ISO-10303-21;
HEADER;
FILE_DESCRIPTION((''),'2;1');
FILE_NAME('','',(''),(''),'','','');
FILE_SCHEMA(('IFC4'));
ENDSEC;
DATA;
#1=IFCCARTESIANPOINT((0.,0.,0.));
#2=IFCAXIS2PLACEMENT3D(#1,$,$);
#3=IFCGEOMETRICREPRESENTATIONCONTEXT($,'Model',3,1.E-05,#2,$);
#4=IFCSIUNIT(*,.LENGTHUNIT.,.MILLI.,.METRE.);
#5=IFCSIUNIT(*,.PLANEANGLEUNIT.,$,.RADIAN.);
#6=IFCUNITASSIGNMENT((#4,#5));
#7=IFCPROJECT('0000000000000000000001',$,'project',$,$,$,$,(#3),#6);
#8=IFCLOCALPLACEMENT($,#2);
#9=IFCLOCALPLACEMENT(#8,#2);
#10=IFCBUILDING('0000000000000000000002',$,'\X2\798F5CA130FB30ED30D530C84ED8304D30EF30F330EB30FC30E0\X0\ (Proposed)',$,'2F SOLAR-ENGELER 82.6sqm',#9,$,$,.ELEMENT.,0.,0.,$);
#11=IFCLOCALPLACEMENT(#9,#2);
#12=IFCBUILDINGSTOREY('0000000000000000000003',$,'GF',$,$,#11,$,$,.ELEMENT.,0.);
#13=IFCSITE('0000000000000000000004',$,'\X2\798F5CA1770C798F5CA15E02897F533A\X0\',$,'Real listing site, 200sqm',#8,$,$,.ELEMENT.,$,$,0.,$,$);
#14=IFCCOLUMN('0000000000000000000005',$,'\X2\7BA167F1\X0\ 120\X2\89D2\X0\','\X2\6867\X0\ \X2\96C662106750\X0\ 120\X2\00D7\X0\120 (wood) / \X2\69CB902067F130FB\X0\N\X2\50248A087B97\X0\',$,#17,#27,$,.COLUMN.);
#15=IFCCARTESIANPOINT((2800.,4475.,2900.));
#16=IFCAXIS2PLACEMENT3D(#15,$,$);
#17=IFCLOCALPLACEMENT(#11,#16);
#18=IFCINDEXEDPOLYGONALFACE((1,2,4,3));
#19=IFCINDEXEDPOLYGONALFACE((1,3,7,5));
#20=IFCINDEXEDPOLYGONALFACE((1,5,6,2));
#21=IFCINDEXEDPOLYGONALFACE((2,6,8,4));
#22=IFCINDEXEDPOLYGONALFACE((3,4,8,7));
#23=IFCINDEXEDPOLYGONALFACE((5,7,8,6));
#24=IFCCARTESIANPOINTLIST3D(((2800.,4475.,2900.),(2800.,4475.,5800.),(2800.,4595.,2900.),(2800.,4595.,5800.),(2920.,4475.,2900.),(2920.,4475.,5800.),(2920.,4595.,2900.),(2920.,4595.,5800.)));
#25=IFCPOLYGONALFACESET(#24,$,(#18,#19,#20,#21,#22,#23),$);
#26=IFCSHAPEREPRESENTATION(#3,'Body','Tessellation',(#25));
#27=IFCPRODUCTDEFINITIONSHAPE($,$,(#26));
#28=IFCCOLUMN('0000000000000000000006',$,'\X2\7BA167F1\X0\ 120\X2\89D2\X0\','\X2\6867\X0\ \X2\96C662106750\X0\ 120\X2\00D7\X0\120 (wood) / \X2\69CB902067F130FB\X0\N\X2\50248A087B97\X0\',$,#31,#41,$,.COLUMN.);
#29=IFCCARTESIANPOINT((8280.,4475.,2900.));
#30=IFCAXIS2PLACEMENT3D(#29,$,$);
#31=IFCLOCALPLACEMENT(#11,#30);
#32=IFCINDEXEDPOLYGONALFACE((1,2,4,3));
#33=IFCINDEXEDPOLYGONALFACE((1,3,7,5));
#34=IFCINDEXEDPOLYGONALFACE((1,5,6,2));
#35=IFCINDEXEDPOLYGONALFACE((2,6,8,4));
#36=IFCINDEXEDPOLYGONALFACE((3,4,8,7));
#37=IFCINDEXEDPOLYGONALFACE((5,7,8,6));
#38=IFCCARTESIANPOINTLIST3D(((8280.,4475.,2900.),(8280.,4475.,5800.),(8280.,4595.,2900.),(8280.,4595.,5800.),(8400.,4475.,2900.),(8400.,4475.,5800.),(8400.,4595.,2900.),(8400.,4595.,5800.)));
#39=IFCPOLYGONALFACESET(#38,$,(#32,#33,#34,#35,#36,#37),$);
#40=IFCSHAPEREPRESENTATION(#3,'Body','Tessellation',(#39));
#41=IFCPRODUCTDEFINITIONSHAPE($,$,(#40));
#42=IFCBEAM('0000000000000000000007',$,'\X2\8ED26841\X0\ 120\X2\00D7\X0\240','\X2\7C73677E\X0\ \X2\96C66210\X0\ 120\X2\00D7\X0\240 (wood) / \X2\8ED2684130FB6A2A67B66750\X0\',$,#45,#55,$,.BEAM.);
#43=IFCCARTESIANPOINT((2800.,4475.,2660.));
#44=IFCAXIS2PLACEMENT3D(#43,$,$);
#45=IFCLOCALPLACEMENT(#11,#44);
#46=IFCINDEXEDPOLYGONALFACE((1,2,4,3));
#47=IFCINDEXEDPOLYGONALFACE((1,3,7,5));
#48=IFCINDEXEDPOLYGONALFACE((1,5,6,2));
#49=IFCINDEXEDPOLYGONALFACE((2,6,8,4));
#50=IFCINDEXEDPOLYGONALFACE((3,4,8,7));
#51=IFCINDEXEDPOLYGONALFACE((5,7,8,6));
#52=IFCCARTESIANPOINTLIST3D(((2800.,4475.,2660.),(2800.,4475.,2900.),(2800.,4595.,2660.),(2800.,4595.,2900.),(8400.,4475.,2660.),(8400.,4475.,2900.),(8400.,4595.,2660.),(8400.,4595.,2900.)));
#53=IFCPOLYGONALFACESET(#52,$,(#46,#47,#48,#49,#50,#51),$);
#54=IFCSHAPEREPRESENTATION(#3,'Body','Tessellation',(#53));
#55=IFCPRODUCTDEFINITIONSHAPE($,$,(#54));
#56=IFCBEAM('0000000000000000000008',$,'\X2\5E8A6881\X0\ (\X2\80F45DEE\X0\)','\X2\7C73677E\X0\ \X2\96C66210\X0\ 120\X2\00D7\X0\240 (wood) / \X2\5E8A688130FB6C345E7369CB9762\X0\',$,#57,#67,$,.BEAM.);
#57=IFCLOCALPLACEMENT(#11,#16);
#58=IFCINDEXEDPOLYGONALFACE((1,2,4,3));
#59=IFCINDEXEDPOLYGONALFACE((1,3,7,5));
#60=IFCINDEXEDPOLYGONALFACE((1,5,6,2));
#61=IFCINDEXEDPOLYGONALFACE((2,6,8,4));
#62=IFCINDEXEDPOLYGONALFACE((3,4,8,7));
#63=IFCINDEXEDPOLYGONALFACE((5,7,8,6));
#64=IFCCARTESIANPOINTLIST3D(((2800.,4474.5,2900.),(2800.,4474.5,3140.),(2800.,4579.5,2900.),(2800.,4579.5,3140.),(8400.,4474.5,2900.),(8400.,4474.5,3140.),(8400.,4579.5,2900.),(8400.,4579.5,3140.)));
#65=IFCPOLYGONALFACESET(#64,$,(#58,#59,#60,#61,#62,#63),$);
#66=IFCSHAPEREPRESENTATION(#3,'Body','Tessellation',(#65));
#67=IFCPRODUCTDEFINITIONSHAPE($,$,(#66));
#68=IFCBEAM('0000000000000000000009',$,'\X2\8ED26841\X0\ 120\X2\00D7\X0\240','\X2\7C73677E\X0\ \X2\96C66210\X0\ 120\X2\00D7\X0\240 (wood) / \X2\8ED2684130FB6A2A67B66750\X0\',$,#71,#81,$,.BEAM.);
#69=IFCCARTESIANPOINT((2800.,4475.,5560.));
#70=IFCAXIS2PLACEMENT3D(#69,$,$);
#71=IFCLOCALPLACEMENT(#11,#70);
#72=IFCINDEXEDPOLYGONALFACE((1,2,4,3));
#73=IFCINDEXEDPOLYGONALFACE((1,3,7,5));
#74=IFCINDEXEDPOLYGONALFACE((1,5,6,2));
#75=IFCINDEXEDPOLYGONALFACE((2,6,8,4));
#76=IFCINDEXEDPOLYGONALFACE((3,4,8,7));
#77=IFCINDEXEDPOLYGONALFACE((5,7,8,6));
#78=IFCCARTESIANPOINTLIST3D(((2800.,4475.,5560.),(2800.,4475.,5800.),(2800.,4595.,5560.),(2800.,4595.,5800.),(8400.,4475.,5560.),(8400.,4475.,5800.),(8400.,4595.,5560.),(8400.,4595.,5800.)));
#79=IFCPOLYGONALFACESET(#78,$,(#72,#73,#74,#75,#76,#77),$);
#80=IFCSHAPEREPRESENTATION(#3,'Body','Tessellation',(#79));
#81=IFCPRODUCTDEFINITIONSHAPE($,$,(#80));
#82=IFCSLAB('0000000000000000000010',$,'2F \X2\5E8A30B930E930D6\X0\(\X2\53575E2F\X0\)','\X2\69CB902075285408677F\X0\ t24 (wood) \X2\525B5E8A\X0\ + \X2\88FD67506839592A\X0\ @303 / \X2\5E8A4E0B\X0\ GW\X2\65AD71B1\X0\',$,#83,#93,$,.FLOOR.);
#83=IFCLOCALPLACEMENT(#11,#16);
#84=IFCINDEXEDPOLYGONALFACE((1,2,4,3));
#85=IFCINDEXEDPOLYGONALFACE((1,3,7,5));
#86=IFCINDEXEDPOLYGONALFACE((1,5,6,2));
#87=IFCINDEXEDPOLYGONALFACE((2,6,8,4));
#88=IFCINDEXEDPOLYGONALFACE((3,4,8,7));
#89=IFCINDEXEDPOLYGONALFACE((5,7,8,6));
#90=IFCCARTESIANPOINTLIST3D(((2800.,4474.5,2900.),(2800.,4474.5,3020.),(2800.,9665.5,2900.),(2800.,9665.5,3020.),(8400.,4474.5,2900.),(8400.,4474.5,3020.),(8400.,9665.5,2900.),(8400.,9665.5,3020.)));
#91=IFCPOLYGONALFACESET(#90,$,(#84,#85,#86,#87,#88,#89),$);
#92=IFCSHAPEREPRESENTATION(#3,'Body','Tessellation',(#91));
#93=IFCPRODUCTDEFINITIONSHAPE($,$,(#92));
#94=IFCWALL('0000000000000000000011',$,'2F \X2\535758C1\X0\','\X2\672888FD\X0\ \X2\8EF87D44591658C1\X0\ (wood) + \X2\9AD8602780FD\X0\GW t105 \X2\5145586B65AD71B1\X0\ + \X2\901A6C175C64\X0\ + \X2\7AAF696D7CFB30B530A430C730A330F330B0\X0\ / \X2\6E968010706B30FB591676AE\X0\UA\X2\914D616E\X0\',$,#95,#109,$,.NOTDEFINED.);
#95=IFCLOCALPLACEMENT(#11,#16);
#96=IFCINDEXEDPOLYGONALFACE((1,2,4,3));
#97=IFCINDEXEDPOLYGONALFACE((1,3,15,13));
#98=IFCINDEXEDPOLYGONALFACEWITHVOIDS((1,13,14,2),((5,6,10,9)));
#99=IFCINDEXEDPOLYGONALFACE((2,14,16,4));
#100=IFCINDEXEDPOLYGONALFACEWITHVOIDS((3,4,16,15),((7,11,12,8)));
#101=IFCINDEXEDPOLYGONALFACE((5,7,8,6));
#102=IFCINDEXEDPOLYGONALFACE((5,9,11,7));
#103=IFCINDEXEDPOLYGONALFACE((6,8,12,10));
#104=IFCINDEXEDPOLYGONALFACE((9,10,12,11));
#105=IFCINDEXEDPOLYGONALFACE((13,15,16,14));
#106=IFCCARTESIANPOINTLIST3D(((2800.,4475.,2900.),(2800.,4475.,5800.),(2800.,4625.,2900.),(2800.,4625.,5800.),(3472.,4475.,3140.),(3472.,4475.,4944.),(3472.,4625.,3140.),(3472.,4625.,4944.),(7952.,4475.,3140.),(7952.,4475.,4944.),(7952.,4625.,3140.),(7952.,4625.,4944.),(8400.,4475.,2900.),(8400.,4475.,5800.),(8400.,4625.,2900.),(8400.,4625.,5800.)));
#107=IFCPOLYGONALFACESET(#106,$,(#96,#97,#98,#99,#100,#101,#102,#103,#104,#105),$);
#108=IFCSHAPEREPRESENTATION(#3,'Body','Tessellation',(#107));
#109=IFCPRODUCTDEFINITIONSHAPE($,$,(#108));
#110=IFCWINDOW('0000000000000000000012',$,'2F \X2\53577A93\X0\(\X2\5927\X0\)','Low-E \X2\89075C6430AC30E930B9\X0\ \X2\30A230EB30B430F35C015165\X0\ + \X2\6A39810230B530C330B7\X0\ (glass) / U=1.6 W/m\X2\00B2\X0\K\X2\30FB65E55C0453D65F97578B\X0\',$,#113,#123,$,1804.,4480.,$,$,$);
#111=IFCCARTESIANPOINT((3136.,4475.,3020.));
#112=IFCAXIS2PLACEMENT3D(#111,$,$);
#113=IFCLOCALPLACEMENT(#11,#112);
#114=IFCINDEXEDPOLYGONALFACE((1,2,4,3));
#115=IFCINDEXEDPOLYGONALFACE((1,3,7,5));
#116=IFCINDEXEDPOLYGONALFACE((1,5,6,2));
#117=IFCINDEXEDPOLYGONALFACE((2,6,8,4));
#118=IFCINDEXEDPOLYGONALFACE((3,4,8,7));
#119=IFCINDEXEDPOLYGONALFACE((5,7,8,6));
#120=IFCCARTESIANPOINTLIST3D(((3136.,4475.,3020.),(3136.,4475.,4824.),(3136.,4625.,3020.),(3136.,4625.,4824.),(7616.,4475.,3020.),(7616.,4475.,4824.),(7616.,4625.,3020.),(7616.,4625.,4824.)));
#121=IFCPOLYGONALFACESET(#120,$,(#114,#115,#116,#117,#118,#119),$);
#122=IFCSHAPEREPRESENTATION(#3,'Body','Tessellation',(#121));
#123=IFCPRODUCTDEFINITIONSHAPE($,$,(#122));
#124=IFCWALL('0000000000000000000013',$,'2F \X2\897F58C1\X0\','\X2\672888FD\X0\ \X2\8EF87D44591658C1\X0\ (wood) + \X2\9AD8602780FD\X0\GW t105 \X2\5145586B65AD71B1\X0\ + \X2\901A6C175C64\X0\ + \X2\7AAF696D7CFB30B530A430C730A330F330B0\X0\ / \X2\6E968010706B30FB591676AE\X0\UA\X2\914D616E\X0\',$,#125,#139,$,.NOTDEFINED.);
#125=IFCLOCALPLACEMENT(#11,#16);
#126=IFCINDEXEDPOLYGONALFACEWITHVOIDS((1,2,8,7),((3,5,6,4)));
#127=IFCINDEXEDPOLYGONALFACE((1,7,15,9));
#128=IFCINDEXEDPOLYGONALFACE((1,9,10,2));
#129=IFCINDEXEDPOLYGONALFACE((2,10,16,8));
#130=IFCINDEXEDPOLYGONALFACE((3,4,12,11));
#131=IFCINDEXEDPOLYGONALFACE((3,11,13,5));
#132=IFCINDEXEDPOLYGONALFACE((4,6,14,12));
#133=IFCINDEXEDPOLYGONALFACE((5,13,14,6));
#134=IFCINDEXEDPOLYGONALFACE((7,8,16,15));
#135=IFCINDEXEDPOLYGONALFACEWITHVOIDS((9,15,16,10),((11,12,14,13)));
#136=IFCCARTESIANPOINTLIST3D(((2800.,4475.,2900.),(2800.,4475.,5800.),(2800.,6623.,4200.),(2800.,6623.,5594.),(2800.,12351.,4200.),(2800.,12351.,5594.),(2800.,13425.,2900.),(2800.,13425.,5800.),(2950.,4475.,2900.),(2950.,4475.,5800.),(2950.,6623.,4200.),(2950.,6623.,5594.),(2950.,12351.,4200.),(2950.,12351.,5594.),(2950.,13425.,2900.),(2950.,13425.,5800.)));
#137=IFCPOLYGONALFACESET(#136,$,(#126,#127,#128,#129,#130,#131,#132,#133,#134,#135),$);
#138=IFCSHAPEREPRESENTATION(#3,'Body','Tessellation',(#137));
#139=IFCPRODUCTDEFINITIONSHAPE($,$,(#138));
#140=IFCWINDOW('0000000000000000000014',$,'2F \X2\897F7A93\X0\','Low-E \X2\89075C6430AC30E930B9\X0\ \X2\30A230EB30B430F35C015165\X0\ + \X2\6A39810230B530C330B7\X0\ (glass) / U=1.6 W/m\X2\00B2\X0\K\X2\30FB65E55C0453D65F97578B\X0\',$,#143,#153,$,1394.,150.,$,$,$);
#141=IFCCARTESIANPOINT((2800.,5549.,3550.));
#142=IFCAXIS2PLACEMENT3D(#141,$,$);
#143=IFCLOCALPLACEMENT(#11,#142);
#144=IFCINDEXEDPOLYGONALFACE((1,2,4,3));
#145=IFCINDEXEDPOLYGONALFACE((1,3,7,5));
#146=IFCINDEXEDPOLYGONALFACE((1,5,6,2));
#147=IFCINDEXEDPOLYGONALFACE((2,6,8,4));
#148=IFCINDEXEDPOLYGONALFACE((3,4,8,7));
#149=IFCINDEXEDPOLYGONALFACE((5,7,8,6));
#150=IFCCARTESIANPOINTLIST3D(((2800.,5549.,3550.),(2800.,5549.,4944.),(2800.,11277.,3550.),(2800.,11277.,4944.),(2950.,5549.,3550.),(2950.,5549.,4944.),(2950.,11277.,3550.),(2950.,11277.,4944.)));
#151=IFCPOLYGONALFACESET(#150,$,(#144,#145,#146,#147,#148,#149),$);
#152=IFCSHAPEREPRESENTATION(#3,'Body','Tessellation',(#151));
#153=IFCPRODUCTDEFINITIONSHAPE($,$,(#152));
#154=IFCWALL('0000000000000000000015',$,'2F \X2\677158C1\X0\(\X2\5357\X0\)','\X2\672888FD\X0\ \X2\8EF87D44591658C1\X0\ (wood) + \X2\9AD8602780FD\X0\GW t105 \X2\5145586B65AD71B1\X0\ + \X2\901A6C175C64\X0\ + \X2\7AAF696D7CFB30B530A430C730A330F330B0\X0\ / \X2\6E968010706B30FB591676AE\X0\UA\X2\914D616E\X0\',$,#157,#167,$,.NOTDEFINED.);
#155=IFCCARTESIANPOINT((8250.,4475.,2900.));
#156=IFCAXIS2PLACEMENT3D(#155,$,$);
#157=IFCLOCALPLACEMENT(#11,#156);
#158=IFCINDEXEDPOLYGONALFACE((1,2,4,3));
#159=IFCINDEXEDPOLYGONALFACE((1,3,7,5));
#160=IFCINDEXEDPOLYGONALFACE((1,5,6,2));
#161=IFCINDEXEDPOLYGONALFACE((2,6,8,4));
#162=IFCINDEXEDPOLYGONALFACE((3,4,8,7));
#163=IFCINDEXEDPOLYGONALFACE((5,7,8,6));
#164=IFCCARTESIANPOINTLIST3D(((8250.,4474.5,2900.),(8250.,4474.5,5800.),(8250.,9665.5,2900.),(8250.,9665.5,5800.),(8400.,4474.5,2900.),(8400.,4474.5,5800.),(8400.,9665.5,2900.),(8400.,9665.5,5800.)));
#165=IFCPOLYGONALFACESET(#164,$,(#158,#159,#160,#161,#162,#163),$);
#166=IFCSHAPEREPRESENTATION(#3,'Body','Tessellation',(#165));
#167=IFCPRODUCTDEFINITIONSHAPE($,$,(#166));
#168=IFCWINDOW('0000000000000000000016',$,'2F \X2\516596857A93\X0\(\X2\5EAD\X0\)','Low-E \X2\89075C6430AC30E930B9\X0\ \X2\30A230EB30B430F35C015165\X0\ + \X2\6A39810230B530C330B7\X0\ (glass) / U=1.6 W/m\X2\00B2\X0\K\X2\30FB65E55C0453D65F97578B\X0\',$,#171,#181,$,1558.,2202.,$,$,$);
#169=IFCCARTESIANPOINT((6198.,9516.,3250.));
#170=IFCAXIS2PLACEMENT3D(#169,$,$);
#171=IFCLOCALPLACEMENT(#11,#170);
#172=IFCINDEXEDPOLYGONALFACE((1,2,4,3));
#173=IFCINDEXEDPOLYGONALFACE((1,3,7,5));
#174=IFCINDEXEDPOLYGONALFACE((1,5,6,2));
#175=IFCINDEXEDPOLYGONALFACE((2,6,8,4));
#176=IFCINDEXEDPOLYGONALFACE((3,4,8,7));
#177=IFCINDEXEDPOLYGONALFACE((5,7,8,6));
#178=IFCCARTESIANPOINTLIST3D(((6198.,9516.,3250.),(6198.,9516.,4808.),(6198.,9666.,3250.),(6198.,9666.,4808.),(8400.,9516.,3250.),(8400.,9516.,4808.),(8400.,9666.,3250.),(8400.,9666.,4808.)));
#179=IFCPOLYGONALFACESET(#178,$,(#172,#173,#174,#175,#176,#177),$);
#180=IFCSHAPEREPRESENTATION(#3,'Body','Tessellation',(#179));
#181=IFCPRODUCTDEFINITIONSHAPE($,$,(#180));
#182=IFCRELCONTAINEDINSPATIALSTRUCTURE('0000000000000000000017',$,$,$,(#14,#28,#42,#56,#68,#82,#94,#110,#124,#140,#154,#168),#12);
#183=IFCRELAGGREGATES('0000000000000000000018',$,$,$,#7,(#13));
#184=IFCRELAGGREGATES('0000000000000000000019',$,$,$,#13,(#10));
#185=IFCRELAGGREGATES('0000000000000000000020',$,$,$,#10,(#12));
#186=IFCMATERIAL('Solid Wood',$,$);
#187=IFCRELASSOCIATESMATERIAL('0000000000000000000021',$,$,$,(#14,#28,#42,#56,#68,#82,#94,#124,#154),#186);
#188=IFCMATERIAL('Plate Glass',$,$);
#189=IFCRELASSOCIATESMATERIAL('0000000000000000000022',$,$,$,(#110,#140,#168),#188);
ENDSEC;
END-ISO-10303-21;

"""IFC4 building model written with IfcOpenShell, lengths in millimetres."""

from ifc_helpers import new_model, si_unit, frame, frame_2d, origin, place, context, project, spatial, rectangle, extrude, material, element, fill, save


model = new_model("IFC4")

# Units and contexts
model_context = context("Model", 3, precision=1e-05, world=origin())
ifc_project = project(units=[si_unit("LENGTHUNIT", "METRE", prefix="MILLI"), si_unit("PLANEANGLEUNIT", "RADIAN")], contexts=[model_context])

# Site, building, storey
site_placement = place(None, origin())
site = spatial("IfcSite", under=ifc_project, at=site_placement, Name="福岡県福岡市西区", ObjectType="Real listing site, 200sqm", CompositionType="ELEMENT", RefElevation=0.0)
building_placement = place(site_placement, origin())
building = spatial("IfcBuilding", under=site, at=building_placement, Name="福岡・ロフト付きワンルーム (Proposed)", ObjectType="2F SOLAR-ENGELER 82.6sqm", CompositionType="ELEMENT", ElevationOfRefHeight=0.0, ElevationOfTerrain=0.0)
storey_placement = place(building_placement, origin())
storey = spatial("IfcBuildingStorey", under=building, at=storey_placement, Name="GF", CompositionType="ELEMENT", Elevation=0.0)

# Columns
ifc_material_1 = material(Name="Solid Wood")
column_1_placement = place(storey_placement, frame((2800.0, 4475.0, 2900.0)))
element("IfcColumn", 1, at=column_1_placement, inside=storey, material=ifc_material_1, Name="管柱 120角", Description="桧 集成材 120×120 (wood) / 構造柱・N値計算", PredefinedType="COLUMN", context=model_context, shape_type="SweptSolid", body=[
    extrude(rectangle(XDim=120.0, YDim=120.0, at=frame_2d((60.0, 60.0))), frame((2800.0, 4475.0, 2900.0)), (0.0, 0.0, 1.0), 2900.0),
])
column_2_placement = place(storey_placement, frame((8280.0, 4475.0, 2900.0)))
element("IfcColumn", 2, at=column_2_placement, inside=storey, material=ifc_material_1, Name="管柱 120角", Description="桧 集成材 120×120 (wood) / 構造柱・N値計算", PredefinedType="COLUMN", context=model_context, shape_type="SweptSolid", body=[
    extrude(rectangle(XDim=120.0, YDim=120.0, at=frame_2d((60.0, 60.0))), frame((8280.0, 4475.0, 2900.0)), (0.0, 0.0, 1.0), 2900.0),
])

# Beams
beam_1_placement = place(storey_placement, frame((2800.0, 4475.0, 2660.0)))
element("IfcBeam", 3, at=beam_1_placement, inside=storey, material=ifc_material_1, Name="軒桁 120×240", Description="米松 集成 120×240 (wood) / 軒桁・横架材", PredefinedType="BEAM", context=model_context, shape_type="SweptSolid", body=[
    extrude(rectangle(XDim=5600.0, YDim=120.0, at=frame_2d((2800.0, 60.0))), frame((2800.0, 4475.0, 2660.0)), (0.0, 0.0, 1.0), 240.0),
])
beam_2_placement = place(storey_placement, frame((2800.0, 4475.0, 2900.0)))
element("IfcBeam", 4, at=beam_2_placement, inside=storey, material=ifc_material_1, Name="床梁 (胴差)", Description="米松 集成 120×240 (wood) / 床梁・水平構面", PredefinedType="BEAM", context=model_context, shape_type="SweptSolid", body=[
    extrude(rectangle(XDim=5600.0, YDim=105.0, at=frame_2d((2800.0, 52.0))), frame((2800.0, 4475.0, 2900.0)), (0.0, 0.0, 1.0), 240.0),
])
beam_3_placement = place(storey_placement, frame((2800.0, 4475.0, 5560.0)))
element("IfcBeam", 5, at=beam_3_placement, inside=storey, material=ifc_material_1, Name="軒桁 120×240", Description="米松 集成 120×240 (wood) / 軒桁・横架材", PredefinedType="BEAM", context=model_context, shape_type="SweptSolid", body=[
    extrude(rectangle(XDim=5600.0, YDim=120.0, at=frame_2d((2800.0, 60.0))), frame((2800.0, 4475.0, 5560.0)), (0.0, 0.0, 1.0), 240.0),
])

# Slab
slab_placement = place(storey_placement, frame((2800.0, 4475.0, 2900.0)))
element("IfcSlab", 6, at=slab_placement, inside=storey, material=ifc_material_1, Name="2F 床スラブ(南帯)", Description="構造用合板 t24 (wood) 剛床 + 製材根太 @303 / 床下 GW断熱", PredefinedType="FLOOR", context=model_context, shape_type="SweptSolid", body=[
    extrude(rectangle(XDim=5600.0, YDim=5191.0, at=frame_2d((2800.0, 2595.0))), frame((2800.0, 4475.0, 2900.0)), (0.0, 0.0, 1.0), 120.0),
])

# Walls, openings, windows
wall_1_placement = place(storey_placement, frame((2800.0, 4475.0, 2900.0)))
wall_1 = element("IfcWall", 7, at=wall_1_placement, inside=storey, material=ifc_material_1, Name="2F 南壁", Description="木製 軸組外壁 (wood) + 高性能GW t105 充填断熱 + 通気層 + 窯業系サイディング / 準耐火・外皮UA配慮", PredefinedType="NOTDEFINED", context=model_context, shape_type="SweptSolid", body=[
    extrude(rectangle(XDim=5600.0, YDim=150.0, at=frame_2d((2800.0, 75.0))), frame((2800.0, 4475.0, 2900.0)), (0.0, 0.0, 1.0), 2900.0),
])
opening_1_placement = place(storey_placement, frame((3136.0, 4475.0, 3020.0)))
opening_1 = element("IfcOpeningElement", 8, at=opening_1_placement, cuts=wall_1, PredefinedType="NOTDEFINED", context=model_context, shape_type="SweptSolid", body=[
    extrude(rectangle(XDim=4480.0, YDim=150.0, at=frame_2d((2240.0, 75.0))), frame((3136.0, 4475.0, 3020.0)), (0.0, 0.0, 1.0), 1804.0),
])
ifc_material_2 = material(Name="Plate Glass")
window_1_placement = place(storey_placement, frame((3136.0, 4475.0, 3020.0)))
window_1 = element("IfcWindow", 9, at=window_1_placement, inside=storey, material=ifc_material_2, Name="2F 南窓(大)", Description="Low-E 複層ガラス アルゴン封入 + 樹脂サッシ (glass) / U=1.6 W/m²K・日射取得型", OverallHeight=1804.0, OverallWidth=4480.0, context=model_context, shape_type="SweptSolid", body=[
    extrude(rectangle(XDim=4480.0, YDim=150.0, at=frame_2d((2240.0, 75.0))), frame((3136.0, 4475.0, 3020.0)), (0.0, 0.0, 1.0), 1804.0),
])
fill(opening_1, window_1)
wall_2_placement = place(storey_placement, frame((2800.0, 4475.0, 2900.0)))
wall_2 = element("IfcWall", 10, at=wall_2_placement, inside=storey, material=ifc_material_1, Name="2F 西壁", Description="木製 軸組外壁 (wood) + 高性能GW t105 充填断熱 + 通気層 + 窯業系サイディング / 準耐火・外皮UA配慮", PredefinedType="NOTDEFINED", context=model_context, shape_type="SweptSolid", body=[
    extrude(rectangle(XDim=150.0, YDim=8950.0, at=frame_2d((75.0, 4475.0))), frame((2800.0, 4475.0, 2900.0)), (0.0, 0.0, 1.0), 2900.0),
])
opening_2_placement = place(storey_placement, frame((2800.0, 5549.0, 3550.0)))
opening_2 = element("IfcOpeningElement", 11, at=opening_2_placement, cuts=wall_2, PredefinedType="NOTDEFINED", context=model_context, shape_type="SweptSolid", body=[
    extrude(rectangle(XDim=150.0, YDim=5728.0, at=frame_2d((75.0, 2864.0))), frame((2800.0, 5549.0, 3550.0)), (0.0, 0.0, 1.0), 1394.0),
])
window_2_placement = place(storey_placement, frame((2800.0, 5549.0, 3550.0)))
window_2 = element("IfcWindow", 12, at=window_2_placement, inside=storey, material=ifc_material_2, Name="2F 西窓", Description="Low-E 複層ガラス アルゴン封入 + 樹脂サッシ (glass) / U=1.6 W/m²K・日射取得型", OverallHeight=1394.0, OverallWidth=150.0, context=model_context, shape_type="SweptSolid", body=[
    extrude(rectangle(XDim=150.0, YDim=5728.0, at=frame_2d((75.0, 2864.0))), frame((2800.0, 5549.0, 3550.0)), (0.0, 0.0, 1.0), 1394.0),
])
fill(opening_2, window_2)
wall_3_placement = place(storey_placement, frame((8250.0, 4475.0, 2900.0)))
wall_3 = element("IfcWall", 13, at=wall_3_placement, inside=storey, material=ifc_material_1, Name="2F 東壁(南)", Description="木製 軸組外壁 (wood) + 高性能GW t105 充填断熱 + 通気層 + 窯業系サイディング / 準耐火・外皮UA配慮", PredefinedType="NOTDEFINED", context=model_context, shape_type="SweptSolid", body=[
    extrude(rectangle(XDim=150.0, YDim=5191.0, at=frame_2d((75.0, 2595.0))), frame((8250.0, 4475.0, 2900.0)), (0.0, 0.0, 1.0), 2900.0),
])
opening_3_placement = place(storey_placement, frame((6198.0, 9516.0, 3250.0)))
opening_3 = element("IfcOpeningElement", 14, at=opening_3_placement, cuts=wall_3, PredefinedType="NOTDEFINED", context=model_context, shape_type="SweptSolid", body=[
    extrude(rectangle(XDim=2202.0, YDim=150.0, at=frame_2d((1101.0, 75.0))), frame((6198.0, 9516.0, 3250.0)), (0.0, 0.0, 1.0), 1558.0),
])
window_3_placement = place(storey_placement, frame((6198.0, 9516.0, 3250.0)))
window_3 = element("IfcWindow", 15, at=window_3_placement, inside=storey, material=ifc_material_2, Name="2F 入隅窓(庭)", Description="Low-E 複層ガラス アルゴン封入 + 樹脂サッシ (glass) / U=1.6 W/m²K・日射取得型", OverallHeight=1558.0, OverallWidth=2202.0, context=model_context, shape_type="SweptSolid", body=[
    extrude(rectangle(XDim=2202.0, YDim=150.0, at=frame_2d((1101.0, 75.0))), frame((6198.0, 9516.0, 3250.0)), (0.0, 0.0, 1.0), 1558.0),
])
fill(opening_3, window_3)

save(model, "model.ifc")
